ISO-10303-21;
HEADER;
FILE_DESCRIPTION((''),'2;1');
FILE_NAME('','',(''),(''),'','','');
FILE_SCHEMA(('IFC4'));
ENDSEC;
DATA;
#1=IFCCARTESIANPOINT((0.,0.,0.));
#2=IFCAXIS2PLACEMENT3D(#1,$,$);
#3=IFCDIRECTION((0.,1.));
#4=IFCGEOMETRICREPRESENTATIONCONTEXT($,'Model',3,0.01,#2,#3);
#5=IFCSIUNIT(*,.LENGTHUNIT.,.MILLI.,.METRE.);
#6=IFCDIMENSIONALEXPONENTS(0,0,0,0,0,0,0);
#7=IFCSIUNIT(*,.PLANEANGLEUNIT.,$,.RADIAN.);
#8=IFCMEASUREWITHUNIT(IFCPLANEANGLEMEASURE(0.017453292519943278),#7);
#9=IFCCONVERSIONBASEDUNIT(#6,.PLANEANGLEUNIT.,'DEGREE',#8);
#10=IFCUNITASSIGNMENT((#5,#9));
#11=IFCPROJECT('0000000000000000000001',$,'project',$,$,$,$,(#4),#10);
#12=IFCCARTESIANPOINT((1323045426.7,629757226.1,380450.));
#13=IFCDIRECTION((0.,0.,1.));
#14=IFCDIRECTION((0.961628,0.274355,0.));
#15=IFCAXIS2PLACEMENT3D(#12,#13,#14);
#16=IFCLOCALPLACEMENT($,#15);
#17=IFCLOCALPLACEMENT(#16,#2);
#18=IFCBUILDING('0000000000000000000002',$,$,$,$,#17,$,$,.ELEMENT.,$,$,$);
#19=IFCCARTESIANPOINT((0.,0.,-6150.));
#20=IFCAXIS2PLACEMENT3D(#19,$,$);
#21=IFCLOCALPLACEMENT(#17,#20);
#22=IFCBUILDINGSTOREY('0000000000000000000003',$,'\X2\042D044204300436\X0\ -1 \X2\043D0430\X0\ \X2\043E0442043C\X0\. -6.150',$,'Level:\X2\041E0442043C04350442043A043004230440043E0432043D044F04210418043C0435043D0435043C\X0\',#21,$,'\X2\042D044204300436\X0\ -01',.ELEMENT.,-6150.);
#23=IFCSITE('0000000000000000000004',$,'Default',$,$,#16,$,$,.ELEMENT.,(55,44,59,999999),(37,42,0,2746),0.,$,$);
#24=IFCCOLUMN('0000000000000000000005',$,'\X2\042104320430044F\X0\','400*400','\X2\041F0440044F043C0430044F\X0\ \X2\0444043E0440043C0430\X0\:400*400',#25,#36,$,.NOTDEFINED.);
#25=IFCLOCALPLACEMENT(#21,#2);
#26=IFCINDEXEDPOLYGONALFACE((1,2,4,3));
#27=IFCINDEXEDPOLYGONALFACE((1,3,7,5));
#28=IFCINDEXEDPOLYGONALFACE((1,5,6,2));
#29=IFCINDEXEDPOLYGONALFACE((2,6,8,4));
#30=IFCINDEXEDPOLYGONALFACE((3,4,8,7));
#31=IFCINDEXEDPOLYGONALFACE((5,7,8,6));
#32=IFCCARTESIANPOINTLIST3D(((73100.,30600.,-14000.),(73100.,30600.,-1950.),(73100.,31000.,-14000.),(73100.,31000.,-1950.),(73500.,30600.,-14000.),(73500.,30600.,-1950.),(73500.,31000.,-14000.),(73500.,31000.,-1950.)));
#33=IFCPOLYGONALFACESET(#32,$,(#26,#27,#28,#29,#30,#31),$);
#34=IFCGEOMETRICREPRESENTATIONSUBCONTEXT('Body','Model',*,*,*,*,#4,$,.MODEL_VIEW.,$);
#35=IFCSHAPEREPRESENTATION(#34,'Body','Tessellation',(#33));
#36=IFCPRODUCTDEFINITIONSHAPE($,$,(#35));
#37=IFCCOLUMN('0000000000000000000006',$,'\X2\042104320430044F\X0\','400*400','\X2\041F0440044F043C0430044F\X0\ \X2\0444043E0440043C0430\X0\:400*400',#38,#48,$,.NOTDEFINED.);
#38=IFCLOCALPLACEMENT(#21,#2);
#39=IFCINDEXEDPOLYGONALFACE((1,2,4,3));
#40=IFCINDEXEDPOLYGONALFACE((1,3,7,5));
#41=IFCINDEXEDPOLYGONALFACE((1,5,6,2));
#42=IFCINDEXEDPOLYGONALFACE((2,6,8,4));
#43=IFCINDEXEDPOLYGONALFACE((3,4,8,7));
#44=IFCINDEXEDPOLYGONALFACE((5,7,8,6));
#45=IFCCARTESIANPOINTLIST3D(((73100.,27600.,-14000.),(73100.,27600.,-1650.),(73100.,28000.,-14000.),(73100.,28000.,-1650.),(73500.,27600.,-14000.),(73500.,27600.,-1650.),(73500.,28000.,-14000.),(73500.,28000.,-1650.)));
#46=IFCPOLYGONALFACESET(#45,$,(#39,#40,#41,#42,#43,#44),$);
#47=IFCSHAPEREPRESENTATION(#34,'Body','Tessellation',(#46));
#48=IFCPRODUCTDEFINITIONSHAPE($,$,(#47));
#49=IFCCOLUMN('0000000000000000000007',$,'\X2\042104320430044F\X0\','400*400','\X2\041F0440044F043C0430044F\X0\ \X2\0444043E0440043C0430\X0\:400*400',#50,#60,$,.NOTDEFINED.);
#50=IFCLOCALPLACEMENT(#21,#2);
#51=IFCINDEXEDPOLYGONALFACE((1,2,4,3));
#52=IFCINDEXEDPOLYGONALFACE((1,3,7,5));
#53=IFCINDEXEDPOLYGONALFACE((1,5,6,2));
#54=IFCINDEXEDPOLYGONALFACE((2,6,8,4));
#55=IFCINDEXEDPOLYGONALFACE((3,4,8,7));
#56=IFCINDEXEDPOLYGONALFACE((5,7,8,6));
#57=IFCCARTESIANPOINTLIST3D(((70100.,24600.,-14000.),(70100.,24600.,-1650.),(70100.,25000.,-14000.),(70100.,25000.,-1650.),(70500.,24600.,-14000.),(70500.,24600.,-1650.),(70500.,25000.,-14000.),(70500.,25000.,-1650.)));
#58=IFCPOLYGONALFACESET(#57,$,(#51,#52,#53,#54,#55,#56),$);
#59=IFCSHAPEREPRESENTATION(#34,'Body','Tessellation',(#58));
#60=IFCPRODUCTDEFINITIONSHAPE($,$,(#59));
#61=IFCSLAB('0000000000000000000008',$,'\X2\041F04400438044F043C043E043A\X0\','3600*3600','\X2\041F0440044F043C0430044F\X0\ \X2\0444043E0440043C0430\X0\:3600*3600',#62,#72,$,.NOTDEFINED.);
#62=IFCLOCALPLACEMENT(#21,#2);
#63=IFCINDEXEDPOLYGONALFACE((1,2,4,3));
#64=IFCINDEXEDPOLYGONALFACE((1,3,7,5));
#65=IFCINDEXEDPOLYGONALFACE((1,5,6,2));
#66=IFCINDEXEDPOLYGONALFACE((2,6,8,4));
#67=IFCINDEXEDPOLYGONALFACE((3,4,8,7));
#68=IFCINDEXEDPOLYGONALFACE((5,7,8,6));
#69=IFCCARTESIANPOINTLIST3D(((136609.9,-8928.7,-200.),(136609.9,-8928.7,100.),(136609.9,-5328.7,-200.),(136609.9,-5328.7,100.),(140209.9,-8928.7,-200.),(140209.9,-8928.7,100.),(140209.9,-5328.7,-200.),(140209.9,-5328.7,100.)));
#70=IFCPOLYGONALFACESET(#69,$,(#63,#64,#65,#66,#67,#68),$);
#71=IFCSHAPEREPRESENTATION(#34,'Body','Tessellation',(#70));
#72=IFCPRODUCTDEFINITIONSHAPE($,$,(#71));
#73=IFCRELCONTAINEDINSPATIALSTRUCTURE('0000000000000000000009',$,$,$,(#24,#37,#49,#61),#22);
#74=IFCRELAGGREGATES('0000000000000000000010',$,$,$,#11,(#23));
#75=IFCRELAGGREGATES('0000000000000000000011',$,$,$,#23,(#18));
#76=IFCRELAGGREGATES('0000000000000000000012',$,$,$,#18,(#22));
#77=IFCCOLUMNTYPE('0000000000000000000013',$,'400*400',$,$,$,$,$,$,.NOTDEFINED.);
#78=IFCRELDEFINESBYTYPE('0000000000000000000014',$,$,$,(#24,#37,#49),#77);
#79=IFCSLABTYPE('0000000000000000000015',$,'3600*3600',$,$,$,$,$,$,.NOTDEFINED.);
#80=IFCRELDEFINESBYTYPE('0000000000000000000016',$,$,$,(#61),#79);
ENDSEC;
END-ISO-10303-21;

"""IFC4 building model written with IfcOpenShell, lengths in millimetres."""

from ifc_helpers import new_model, entity, si_unit, converted_unit, direction, frame, origin, place, context, subcontext, project, spatial, indexed_curve, outline, extrude, type_object, element, save


model = new_model("IFC4")

# Units and contexts
model_context = context("Model", 3, precision=0.01, world=origin(), true_north=direction((0.0, 1.0)))
body_context = subcontext(model_context, "Body", "Model", "MODEL_VIEW")
ifc_project = project(units=[si_unit("LENGTHUNIT", "METRE", prefix="MILLI"), converted_unit("PLANEANGLEUNIT", "DEGREE", entity("IfcPlaneAngleMeasure", 0.017453292519943278), si_unit("PLANEANGLEUNIT", "RADIAN"), dimensions=[0, 0, 0, 0, 0, 0, 0])], contexts=[model_context])

# Site, building, storey
site_placement = place(None, frame((1323045426.7, 629757226.1, 380450.0), z_axis=(0.0, 0.0, 1.0), x_axis=(0.961628, 0.274355, 0.0)))
site = spatial("IfcSite", under=ifc_project, at=site_placement, Name="Default", CompositionType="ELEMENT", RefLatitude=(55, 44, 59, 999999), RefLongitude=(37, 42, 0, 2746), RefElevation=0.0)
building_placement = place(site_placement, origin())
building = spatial("IfcBuilding", under=site, at=building_placement, CompositionType="ELEMENT")
storey_placement = place(building_placement, frame((0.0, 0.0, -6150.0)))
storey = spatial("IfcBuildingStorey", under=building, at=storey_placement, Name="Этаж -1 на отм. -6.150", ObjectType="Level:ОтметкаУровняСИменем", LongName="Этаж -01", CompositionType="ELEMENT", Elevation=-6150.0)

# Columns
column_type = type_object("IfcColumnType", Name="400*400", PredefinedType="NOTDEFINED")
column_1_placement = place(storey_placement, origin())
element("IfcColumn", 1, at=column_1_placement, inside=storey, type_object=column_type, Name="Свая", Description="400*400", ObjectType="Прямая форма:400*400", PredefinedType="NOTDEFINED", context=body_context, shape_type="SweptSolid", body=[
    extrude(outline(indexed_curve([(-200.0, -200.0), (200.0, -200.0), (200.0, 200.0), (-200.0, 200.0), (-200.0, -200.0)], self_intersect=False)), frame((73300.0, 30800.0, -14000.0), z_axis=(0.0, 0.0, 1.0), x_axis=(0.0, 1.0, 0.0)), (0.0, 0.0, 1.0), 12050.0),
])
column_2_placement = place(storey_placement, origin())
element("IfcColumn", 2, at=column_2_placement, inside=storey, type_object=column_type, Name="Свая", Description="400*400", ObjectType="Прямая форма:400*400", PredefinedType="NOTDEFINED", context=body_context, shape_type="SweptSolid", body=[
    extrude(outline(indexed_curve([(-200.0, -200.0), (200.0, -200.0), (200.0, 200.0), (-200.0, 200.0), (-200.0, -200.0)], self_intersect=False)), frame((73300.0, 27800.0, -14000.0), z_axis=(0.0, 0.0, 1.0), x_axis=(0.0, 1.0, 0.0)), (0.0, 0.0, 1.0), 12350.0),
])
column_3_placement = place(storey_placement, origin())
element("IfcColumn", 3, at=column_3_placement, inside=storey, type_object=column_type, Name="Свая", Description="400*400", ObjectType="Прямая форма:400*400", PredefinedType="NOTDEFINED", context=body_context, shape_type="SweptSolid", body=[
    extrude(outline(indexed_curve([(-200.0, -200.0), (200.0, -200.0), (200.0, 200.0), (-200.0, 200.0), (-200.0, -200.0)], self_intersect=False)), frame((70300.0, 24800.0, -14000.0), z_axis=(0.0, 0.0, 1.0), x_axis=(0.0, 1.0, 0.0)), (0.0, 0.0, 1.0), 12350.0),
])

# Slab
slab_type = type_object("IfcSlabType", Name="3600*3600", PredefinedType="NOTDEFINED")
slab_placement = place(storey_placement, origin())
element("IfcSlab", 4, at=slab_placement, inside=storey, type_object=slab_type, Name="Приямок", Description="3600*3600", ObjectType="Прямая форма:3600*3600", PredefinedType="NOTDEFINED", context=body_context, shape_type="SweptSolid", body=[
    extrude(outline(indexed_curve([(-1800.0, -1800.0), (1800.0, -1800.0), (1800.0, 1800.0), (-1800.0, 1800.0), (-1800.0, -1800.0)], self_intersect=False)), frame((138409.9, -7128.7, -200.0)), (0.0, 0.0, 1.0), 300.0),
])

save(model, "model.ifc")
